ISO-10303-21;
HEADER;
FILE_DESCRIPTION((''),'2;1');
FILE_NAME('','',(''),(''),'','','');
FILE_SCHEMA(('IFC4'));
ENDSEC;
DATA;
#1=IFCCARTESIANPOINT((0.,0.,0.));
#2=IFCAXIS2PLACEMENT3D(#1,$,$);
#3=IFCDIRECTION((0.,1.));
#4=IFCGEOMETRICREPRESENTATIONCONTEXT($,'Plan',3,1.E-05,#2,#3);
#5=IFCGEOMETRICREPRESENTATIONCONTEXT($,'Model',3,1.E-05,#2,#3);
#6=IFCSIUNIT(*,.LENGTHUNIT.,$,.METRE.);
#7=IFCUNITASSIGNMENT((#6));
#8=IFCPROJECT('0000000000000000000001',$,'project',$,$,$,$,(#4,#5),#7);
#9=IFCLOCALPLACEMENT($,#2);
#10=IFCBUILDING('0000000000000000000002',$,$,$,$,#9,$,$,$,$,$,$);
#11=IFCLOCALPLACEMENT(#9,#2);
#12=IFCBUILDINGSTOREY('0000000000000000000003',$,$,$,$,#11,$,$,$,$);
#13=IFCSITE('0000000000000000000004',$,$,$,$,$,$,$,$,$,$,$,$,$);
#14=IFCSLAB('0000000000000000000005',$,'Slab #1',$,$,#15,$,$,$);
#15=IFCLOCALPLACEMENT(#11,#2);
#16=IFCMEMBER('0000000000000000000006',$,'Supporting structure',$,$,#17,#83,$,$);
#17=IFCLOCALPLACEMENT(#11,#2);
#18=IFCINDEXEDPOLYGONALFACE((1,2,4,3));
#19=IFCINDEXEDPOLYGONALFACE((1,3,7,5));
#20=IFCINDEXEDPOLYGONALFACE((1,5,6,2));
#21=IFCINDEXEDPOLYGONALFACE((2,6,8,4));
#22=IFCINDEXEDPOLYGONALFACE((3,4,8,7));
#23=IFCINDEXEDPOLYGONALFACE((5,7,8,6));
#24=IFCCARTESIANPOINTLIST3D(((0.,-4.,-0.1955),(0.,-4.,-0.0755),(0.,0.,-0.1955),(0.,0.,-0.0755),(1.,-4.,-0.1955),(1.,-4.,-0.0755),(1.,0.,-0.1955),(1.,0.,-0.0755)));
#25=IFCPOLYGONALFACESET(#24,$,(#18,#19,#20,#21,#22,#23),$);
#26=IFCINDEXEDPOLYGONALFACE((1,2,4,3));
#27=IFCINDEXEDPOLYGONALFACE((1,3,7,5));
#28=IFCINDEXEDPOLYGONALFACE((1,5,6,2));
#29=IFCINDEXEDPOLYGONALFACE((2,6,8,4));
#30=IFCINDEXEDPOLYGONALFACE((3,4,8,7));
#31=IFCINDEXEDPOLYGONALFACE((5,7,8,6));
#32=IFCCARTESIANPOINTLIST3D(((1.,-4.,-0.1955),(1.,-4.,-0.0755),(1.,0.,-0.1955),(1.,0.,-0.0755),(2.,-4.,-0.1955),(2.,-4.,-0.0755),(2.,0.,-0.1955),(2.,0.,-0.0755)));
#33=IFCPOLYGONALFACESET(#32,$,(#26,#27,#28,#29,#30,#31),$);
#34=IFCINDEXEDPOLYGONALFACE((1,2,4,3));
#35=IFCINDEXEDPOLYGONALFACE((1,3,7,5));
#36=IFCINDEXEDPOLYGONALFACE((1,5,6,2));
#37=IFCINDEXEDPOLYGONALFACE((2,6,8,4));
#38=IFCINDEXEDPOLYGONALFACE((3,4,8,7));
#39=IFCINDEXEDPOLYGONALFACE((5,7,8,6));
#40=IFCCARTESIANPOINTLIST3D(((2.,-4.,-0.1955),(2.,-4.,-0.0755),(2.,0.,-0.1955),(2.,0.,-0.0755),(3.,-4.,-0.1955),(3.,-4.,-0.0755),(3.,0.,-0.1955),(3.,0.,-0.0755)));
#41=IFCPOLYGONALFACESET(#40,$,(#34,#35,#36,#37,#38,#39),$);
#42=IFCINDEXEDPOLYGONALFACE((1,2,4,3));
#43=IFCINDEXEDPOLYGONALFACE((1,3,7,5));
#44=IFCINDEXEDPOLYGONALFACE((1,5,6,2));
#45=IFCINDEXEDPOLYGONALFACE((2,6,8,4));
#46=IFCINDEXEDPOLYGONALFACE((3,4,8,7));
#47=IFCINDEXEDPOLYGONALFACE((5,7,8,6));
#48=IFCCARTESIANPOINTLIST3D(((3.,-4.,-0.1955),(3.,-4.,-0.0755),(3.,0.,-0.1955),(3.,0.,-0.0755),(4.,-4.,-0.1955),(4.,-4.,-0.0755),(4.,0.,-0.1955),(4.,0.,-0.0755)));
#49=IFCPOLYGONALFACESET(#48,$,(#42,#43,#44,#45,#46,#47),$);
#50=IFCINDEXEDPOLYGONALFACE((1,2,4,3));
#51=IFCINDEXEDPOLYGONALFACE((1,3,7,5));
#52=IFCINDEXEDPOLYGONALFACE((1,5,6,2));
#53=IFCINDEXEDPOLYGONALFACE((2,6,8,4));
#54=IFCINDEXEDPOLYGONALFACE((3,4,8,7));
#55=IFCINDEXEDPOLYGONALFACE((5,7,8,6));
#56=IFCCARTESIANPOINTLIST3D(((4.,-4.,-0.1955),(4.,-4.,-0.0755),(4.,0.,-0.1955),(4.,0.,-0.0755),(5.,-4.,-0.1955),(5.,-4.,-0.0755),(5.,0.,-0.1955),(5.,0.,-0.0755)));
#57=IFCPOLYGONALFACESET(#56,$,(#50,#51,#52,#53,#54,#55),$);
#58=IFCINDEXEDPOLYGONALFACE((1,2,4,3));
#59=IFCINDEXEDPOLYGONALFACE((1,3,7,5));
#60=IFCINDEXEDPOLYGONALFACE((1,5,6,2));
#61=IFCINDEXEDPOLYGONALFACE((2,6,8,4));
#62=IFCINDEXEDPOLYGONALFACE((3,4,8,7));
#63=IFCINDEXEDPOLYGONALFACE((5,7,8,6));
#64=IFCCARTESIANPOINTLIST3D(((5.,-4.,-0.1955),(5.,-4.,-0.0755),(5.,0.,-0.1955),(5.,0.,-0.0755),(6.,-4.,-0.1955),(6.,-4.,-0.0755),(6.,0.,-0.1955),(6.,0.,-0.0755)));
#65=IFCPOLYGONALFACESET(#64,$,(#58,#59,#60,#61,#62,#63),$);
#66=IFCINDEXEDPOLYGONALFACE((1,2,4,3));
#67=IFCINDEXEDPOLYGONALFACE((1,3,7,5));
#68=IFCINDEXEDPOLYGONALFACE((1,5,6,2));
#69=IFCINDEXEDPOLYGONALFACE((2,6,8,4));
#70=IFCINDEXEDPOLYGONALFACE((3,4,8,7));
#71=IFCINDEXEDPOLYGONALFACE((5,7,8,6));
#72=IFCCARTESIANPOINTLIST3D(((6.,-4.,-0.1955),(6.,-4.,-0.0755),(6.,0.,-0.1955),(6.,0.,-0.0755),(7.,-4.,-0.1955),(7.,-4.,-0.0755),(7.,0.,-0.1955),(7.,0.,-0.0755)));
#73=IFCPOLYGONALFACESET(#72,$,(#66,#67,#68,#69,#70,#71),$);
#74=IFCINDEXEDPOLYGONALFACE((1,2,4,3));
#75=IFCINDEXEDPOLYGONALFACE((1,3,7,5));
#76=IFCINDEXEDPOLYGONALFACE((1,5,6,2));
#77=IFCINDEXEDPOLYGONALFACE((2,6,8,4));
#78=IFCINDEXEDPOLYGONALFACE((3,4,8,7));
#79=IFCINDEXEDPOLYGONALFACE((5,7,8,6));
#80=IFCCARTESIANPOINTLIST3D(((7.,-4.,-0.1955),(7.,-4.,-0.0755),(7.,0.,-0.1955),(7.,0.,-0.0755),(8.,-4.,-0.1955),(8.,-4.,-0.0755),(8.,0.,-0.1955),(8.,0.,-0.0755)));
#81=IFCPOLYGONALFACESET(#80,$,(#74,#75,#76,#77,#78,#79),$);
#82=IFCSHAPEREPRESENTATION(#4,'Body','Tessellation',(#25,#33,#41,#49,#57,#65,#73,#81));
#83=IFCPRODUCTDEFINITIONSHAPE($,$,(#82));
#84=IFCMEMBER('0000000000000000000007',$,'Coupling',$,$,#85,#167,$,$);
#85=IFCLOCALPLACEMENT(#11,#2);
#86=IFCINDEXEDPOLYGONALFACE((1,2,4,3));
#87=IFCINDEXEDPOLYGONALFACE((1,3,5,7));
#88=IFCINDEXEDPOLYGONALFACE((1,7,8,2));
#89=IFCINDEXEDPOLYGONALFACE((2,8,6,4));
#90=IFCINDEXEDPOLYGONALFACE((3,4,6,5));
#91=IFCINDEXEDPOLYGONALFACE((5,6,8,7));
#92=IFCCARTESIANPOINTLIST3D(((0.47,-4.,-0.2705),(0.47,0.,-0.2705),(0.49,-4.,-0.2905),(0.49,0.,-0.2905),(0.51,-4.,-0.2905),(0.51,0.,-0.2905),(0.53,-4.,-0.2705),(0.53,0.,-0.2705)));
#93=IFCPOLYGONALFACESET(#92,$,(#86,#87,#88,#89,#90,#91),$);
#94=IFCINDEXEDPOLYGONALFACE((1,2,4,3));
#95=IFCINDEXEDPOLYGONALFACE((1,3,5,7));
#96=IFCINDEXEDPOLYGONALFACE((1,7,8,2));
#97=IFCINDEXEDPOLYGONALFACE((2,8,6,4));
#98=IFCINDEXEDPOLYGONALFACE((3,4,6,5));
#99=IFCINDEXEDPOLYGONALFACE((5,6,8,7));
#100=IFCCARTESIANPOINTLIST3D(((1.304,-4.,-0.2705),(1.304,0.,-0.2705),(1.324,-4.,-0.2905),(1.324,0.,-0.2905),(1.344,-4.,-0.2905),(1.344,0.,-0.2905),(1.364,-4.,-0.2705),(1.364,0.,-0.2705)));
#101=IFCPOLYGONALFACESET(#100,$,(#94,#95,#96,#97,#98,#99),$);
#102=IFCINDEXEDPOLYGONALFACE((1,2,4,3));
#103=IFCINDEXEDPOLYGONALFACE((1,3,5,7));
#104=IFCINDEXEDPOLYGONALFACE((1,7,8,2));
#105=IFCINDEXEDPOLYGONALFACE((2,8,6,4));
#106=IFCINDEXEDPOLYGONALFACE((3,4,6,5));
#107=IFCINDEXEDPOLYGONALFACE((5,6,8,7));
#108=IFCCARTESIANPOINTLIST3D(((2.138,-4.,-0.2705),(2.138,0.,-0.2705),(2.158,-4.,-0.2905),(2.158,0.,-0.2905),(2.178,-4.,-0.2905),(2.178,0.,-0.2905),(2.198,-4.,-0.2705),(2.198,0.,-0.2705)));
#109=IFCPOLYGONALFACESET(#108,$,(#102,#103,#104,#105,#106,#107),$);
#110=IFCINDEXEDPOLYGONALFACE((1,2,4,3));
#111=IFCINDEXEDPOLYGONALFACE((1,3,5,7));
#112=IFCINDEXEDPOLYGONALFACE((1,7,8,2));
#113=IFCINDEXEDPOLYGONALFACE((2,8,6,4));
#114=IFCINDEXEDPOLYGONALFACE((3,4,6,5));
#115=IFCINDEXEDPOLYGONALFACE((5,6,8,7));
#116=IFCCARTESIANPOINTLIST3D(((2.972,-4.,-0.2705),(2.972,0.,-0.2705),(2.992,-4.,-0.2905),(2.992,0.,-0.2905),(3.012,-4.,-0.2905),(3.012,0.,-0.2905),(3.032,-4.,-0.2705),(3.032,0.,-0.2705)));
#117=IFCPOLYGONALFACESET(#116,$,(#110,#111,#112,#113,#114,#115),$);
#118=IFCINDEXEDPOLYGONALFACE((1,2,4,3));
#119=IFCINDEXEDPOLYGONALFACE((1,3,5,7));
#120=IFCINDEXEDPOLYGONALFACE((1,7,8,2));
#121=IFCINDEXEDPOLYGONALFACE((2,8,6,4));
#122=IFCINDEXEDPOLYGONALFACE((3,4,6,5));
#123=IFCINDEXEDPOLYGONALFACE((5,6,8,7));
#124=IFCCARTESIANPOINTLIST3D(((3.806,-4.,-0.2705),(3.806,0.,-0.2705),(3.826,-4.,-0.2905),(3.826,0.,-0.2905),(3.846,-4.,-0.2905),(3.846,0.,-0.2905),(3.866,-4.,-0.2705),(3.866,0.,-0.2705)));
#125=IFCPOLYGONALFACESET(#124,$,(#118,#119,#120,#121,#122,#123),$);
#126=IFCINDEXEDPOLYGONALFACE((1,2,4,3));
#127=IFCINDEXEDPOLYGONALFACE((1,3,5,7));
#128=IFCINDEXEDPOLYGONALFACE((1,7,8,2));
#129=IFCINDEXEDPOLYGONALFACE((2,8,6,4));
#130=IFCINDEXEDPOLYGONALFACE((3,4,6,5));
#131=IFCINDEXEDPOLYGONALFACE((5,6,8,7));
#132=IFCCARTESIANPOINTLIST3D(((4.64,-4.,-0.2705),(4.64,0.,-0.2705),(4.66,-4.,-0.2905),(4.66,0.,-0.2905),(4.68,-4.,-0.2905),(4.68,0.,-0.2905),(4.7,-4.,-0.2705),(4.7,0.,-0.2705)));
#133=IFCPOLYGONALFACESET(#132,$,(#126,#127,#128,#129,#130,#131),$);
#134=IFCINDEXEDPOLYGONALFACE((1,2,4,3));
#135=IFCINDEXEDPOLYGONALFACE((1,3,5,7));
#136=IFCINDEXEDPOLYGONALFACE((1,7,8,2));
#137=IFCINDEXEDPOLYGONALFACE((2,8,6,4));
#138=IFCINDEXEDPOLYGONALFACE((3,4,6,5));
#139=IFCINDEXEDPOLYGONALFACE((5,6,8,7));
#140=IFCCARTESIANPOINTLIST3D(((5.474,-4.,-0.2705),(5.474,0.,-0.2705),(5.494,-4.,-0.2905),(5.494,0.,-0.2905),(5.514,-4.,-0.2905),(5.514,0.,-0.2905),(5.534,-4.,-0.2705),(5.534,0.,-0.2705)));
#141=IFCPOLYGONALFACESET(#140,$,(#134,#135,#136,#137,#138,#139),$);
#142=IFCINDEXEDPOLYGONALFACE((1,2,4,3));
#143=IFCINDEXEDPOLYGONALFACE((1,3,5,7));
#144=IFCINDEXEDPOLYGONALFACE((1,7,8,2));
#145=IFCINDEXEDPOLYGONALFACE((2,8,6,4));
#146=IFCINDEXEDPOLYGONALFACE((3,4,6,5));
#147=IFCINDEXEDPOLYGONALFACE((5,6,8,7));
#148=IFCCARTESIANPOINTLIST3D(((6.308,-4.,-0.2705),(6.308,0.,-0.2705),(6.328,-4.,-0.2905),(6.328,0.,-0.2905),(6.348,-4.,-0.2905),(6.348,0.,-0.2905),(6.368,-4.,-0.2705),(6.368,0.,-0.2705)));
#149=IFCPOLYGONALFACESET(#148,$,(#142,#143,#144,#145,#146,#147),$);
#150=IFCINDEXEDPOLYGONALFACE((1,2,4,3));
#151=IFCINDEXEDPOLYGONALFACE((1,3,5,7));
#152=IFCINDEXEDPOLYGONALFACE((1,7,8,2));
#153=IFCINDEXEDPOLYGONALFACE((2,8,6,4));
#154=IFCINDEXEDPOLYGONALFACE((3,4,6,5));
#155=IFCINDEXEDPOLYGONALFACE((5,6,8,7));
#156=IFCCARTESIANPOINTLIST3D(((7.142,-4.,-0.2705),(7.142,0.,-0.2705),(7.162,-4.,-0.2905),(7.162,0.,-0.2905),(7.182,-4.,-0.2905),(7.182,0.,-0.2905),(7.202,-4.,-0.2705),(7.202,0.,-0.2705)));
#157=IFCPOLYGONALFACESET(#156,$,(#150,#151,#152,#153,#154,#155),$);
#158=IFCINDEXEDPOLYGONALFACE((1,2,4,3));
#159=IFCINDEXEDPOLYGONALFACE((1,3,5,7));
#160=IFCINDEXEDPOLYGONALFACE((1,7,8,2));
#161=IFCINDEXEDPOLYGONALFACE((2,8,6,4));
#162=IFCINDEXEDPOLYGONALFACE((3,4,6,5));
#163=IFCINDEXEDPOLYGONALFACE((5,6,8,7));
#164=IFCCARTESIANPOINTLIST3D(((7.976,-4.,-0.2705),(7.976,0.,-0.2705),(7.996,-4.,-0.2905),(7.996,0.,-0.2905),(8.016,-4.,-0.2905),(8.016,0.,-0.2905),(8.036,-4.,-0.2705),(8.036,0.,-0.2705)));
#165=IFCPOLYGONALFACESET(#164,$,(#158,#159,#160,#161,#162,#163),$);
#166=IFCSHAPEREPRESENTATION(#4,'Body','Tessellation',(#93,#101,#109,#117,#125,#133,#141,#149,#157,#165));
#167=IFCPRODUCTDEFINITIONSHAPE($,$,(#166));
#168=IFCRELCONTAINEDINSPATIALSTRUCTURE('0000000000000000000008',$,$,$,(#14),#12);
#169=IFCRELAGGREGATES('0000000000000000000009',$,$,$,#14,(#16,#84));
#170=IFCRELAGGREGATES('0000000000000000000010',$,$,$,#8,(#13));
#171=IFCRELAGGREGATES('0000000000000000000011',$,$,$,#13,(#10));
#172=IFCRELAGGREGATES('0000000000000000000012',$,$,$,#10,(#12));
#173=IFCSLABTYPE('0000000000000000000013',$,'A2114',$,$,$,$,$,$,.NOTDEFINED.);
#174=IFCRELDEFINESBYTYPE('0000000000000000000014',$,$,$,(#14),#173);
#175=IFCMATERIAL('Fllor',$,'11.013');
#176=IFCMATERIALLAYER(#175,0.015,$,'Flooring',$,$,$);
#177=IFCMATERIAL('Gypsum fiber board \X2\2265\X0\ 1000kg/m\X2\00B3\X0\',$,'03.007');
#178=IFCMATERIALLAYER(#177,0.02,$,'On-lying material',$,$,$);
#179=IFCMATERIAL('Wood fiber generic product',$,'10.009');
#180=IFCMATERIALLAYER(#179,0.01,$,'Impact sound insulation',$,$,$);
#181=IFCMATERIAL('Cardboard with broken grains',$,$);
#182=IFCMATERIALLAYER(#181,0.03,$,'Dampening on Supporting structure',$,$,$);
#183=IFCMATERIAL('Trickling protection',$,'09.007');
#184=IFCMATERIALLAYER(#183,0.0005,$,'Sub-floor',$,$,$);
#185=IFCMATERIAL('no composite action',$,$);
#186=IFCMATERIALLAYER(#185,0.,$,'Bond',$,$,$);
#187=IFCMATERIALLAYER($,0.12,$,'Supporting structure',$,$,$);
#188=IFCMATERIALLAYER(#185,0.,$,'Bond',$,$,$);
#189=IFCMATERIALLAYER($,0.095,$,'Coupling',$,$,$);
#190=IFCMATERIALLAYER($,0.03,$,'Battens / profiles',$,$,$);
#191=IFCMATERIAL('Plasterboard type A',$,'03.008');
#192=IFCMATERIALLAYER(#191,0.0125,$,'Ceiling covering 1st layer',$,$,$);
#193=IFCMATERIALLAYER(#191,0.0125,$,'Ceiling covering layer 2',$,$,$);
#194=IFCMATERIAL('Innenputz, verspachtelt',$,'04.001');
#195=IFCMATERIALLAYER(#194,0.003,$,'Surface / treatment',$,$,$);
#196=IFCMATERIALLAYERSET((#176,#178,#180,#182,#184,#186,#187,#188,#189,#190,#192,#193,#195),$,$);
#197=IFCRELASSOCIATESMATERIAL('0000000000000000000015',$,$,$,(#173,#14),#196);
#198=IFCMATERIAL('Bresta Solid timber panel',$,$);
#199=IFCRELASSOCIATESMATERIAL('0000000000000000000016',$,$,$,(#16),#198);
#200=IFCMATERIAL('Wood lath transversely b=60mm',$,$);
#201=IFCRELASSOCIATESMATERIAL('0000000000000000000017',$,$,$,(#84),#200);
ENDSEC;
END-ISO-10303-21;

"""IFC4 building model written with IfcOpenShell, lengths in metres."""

from ifc_helpers import new_model, si_unit, direction, frame, frame_2d, origin, place, context, project, spatial, polyline, rectangle, outline, extrude, material, layer, layer_set, type_object, element, aggregate, save


model = new_model("IFC4")

# Units and contexts
plan_context = context("Plan", 3, precision=1e-05, world=origin(), true_north=direction((0.0, 1.0)))
model_context = context("Model", 3, precision=1e-05, world=origin(), true_north=direction((0.0, 1.0)))
ifc_project = project(units=[si_unit("LENGTHUNIT", "METRE")], contexts=[plan_context, model_context])

# Site, building, storey
site = spatial("IfcSite", under=ifc_project)
building_placement = place(None, origin())
building = spatial("IfcBuilding", under=site, at=building_placement)
storey_placement = place(building_placement, origin())
storey = spatial("IfcBuildingStorey", under=building, at=storey_placement)

# Slab, members
ifc_material_1 = material(Name="Fllor", Category="11.013")
ifc_layer_1 = layer(ifc_material_1, 0.015, Name="Flooring")
ifc_material_2 = material(Name="Gypsum fiber board ≥ 1000kg/m³", Category="03.007")
ifc_layer_2 = layer(ifc_material_2, 0.02, Name="On-lying material")
ifc_material_3 = material(Name="Wood fiber generic product", Category="10.009")
ifc_layer_3 = layer(ifc_material_3, 0.01, Name="Impact sound insulation")
ifc_material_4 = material(Name="Cardboard with broken grains")
ifc_layer_4 = layer(ifc_material_4, 0.03, Name="Dampening on Supporting structure")
ifc_material_5 = material(Name="Trickling protection", Category="09.007")
ifc_layer_5 = layer(ifc_material_5, 0.0005, Name="Sub-floor")
ifc_material_6 = material(Name="no composite action")
ifc_layer_6 = layer(ifc_material_6, 0.0, Name="Bond")
ifc_layer_7 = layer(None, 0.12, Name="Supporting structure")
ifc_layer_8 = layer(ifc_material_6, 0.0, Name="Bond")
ifc_layer_9 = layer(None, 0.095, Name="Coupling")
ifc_layer_10 = layer(None, 0.03, Name="Battens / profiles")
ifc_material_7 = material(Name="Plasterboard type A", Category="03.008")
ifc_layer_11 = layer(ifc_material_7, 0.0125, Name="Ceiling covering 1st layer")
ifc_layer_12 = layer(ifc_material_7, 0.0125, Name="Ceiling covering layer 2")
ifc_material_8 = material(Name="Innenputz, verspachtelt", Category="04.001")
ifc_layer_13 = layer(ifc_material_8, 0.003, Name="Surface / treatment")
ifc_layer_set = layer_set([ifc_layer_1, ifc_layer_2, ifc_layer_3, ifc_layer_4, ifc_layer_5, ifc_layer_6, ifc_layer_7, ifc_layer_8, ifc_layer_9, ifc_layer_10, ifc_layer_11, ifc_layer_12, ifc_layer_13])
slab_type = type_object("IfcSlabType", Name="A2114", PredefinedType="NOTDEFINED", material=ifc_layer_set)
slab_placement = place(None, frame((0.0, 0.0, 0.0), z_axis=(0.0, 0.0, -1.0), x_axis=(1.0, 0.0, 0.0)))
slab = element("IfcSlab", 1, at=slab_placement, inside=storey, type_object=slab_type, material=ifc_layer_set, Name="Slab #1")
ifc_material_9 = material(Name="Bresta Solid timber panel")
member_1_placement = place(slab_placement, origin())
member_1 = element("IfcMember", 2, at=member_1_placement, material=ifc_material_9, Name="Supporting structure", context=plan_context, shape_type="SweptSolid", body=[
    extrude(rectangle(XDim=1.0, YDim=0.12, at=frame_2d((0.5, 0.06), x_axis=(1.0, 0.0))), frame((0.0, 4.0, 0.0755), z_axis=(0.0, -1.0, 0.0), x_axis=(1.0, 0.0, 0.0)), (0.0, 0.0, 1.0), 4.0),
    extrude(rectangle(XDim=1.0, YDim=0.12, at=frame_2d((0.5, 0.06), x_axis=(1.0, 0.0))), frame((1.0, 4.0, 0.0755), z_axis=(0.0, -1.0, 0.0), x_axis=(1.0, 0.0, 0.0)), (0.0, 0.0, 1.0), 4.0),
    extrude(rectangle(XDim=1.0, YDim=0.12, at=frame_2d((0.5, 0.06), x_axis=(1.0, 0.0))), frame((2.0, 4.0, 0.0755), z_axis=(0.0, -1.0, 0.0), x_axis=(1.0, 0.0, 0.0)), (0.0, 0.0, 1.0), 4.0),
    extrude(rectangle(XDim=1.0, YDim=0.12, at=frame_2d((0.5, 0.06), x_axis=(1.0, 0.0))), frame((3.0, 4.0, 0.0755), z_axis=(0.0, -1.0, 0.0), x_axis=(1.0, 0.0, 0.0)), (0.0, 0.0, 1.0), 4.0),
    extrude(rectangle(XDim=1.0, YDim=0.12, at=frame_2d((0.5, 0.06), x_axis=(1.0, 0.0))), frame((4.0, 4.0, 0.0755), z_axis=(0.0, -1.0, 0.0), x_axis=(1.0, 0.0, 0.0)), (0.0, 0.0, 1.0), 4.0),
    extrude(rectangle(XDim=1.0, YDim=0.12, at=frame_2d((0.5, 0.06), x_axis=(1.0, 0.0))), frame((5.0, 4.0, 0.0755), z_axis=(0.0, -1.0, 0.0), x_axis=(1.0, 0.0, 0.0)), (0.0, 0.0, 1.0), 4.0),
    extrude(rectangle(XDim=1.0, YDim=0.12, at=frame_2d((0.5, 0.06), x_axis=(1.0, 0.0))), frame((6.0, 4.0, 0.0755), z_axis=(0.0, -1.0, 0.0), x_axis=(1.0, 0.0, 0.0)), (0.0, 0.0, 1.0), 4.0),
    extrude(rectangle(XDim=1.0, YDim=0.12, at=frame_2d((0.5, 0.06), x_axis=(1.0, 0.0))), frame((7.0, 4.0, 0.0755), z_axis=(0.0, -1.0, 0.0), x_axis=(1.0, 0.0, 0.0)), (0.0, 0.0, 1.0), 4.0),
])
ifc_material_10 = material(Name="Wood lath transversely b=60mm")
member_2_placement = place(slab_placement, origin())
member_2 = element("IfcMember", 3, at=member_2_placement, material=ifc_material_10, Name="Coupling", context=plan_context, shape_type="SweptSolid", body=[
    extrude(outline(polyline([(0.0, 0.0), (0.06, 0.0), (0.04, 0.02), (0.02, 0.02), (0.0, 0.0)])), frame((0.47, 4.0, 0.2705), z_axis=(0.0, -1.0, 0.0), x_axis=(1.0, 0.0, 0.0)), (0.0, 0.0, 1.0), 4.0),
    extrude(outline(polyline([(0.0, 0.0), (0.06, 0.0), (0.04, 0.02), (0.02, 0.02), (0.0, 0.0)])), frame((1.304, 4.0, 0.2705), z_axis=(0.0, -1.0, 0.0), x_axis=(1.0, 0.0, 0.0)), (0.0, 0.0, 1.0), 4.0),
    extrude(outline(polyline([(0.0, 0.0), (0.06, 0.0), (0.04, 0.02), (0.02, 0.02), (0.0, 0.0)])), frame((2.138, 4.0, 0.2705), z_axis=(0.0, -1.0, 0.0), x_axis=(1.0, 0.0, 0.0)), (0.0, 0.0, 1.0), 4.0),
    extrude(outline(polyline([(0.0, 0.0), (0.06, 0.0), (0.04, 0.02), (0.02, 0.02), (0.0, 0.0)])), frame((2.972, 4.0, 0.2705), z_axis=(0.0, -1.0, 0.0), x_axis=(1.0, 0.0, 0.0)), (0.0, 0.0, 1.0), 4.0),
    extrude(outline(polyline([(0.0, 0.0), (0.06, 0.0), (0.04, 0.02), (0.02, 0.02), (0.0, 0.0)])), frame((3.806, 4.0, 0.2705), z_axis=(0.0, -1.0, 0.0), x_axis=(1.0, 0.0, 0.0)), (0.0, 0.0, 1.0), 4.0),
    extrude(outline(polyline([(0.0, 0.0), (0.06, 0.0), (0.04, 0.02), (0.02, 0.02), (0.0, 0.0)])), frame((4.64, 4.0, 0.2705), z_axis=(0.0, -1.0, 0.0), x_axis=(1.0, 0.0, 0.0)), (0.0, 0.0, 1.0), 4.0),
    extrude(outline(polyline([(0.0, 0.0), (0.06, 0.0), (0.04, 0.02), (0.02, 0.02), (0.0, 0.0)])), frame((5.474, 4.0, 0.2705), z_axis=(0.0, -1.0, 0.0), x_axis=(1.0, 0.0, 0.0)), (0.0, 0.0, 1.0), 4.0),
    extrude(outline(polyline([(0.0, 0.0), (0.06, 0.0), (0.04, 0.02), (0.02, 0.02), (0.0, 0.0)])), frame((6.308, 4.0, 0.2705), z_axis=(0.0, -1.0, 0.0), x_axis=(1.0, 0.0, 0.0)), (0.0, 0.0, 1.0), 4.0),
    extrude(outline(polyline([(0.0, 0.0), (0.06, 0.0), (0.04, 0.02), (0.02, 0.02), (0.0, 0.0)])), frame((7.142, 4.0, 0.2705), z_axis=(0.0, -1.0, 0.0), x_axis=(1.0, 0.0, 0.0)), (0.0, 0.0, 1.0), 4.0),
    extrude(outline(polyline([(0.0, 0.0), (0.06, 0.0), (0.04, 0.02), (0.02, 0.02), (0.0, 0.0)])), frame((7.976, 4.0, 0.2705), z_axis=(0.0, -1.0, 0.0), x_axis=(1.0, 0.0, 0.0)), (0.0, 0.0, 1.0), 4.0),
])
aggregate(slab, [member_1, member_2])

save(model, "model.ifc")
